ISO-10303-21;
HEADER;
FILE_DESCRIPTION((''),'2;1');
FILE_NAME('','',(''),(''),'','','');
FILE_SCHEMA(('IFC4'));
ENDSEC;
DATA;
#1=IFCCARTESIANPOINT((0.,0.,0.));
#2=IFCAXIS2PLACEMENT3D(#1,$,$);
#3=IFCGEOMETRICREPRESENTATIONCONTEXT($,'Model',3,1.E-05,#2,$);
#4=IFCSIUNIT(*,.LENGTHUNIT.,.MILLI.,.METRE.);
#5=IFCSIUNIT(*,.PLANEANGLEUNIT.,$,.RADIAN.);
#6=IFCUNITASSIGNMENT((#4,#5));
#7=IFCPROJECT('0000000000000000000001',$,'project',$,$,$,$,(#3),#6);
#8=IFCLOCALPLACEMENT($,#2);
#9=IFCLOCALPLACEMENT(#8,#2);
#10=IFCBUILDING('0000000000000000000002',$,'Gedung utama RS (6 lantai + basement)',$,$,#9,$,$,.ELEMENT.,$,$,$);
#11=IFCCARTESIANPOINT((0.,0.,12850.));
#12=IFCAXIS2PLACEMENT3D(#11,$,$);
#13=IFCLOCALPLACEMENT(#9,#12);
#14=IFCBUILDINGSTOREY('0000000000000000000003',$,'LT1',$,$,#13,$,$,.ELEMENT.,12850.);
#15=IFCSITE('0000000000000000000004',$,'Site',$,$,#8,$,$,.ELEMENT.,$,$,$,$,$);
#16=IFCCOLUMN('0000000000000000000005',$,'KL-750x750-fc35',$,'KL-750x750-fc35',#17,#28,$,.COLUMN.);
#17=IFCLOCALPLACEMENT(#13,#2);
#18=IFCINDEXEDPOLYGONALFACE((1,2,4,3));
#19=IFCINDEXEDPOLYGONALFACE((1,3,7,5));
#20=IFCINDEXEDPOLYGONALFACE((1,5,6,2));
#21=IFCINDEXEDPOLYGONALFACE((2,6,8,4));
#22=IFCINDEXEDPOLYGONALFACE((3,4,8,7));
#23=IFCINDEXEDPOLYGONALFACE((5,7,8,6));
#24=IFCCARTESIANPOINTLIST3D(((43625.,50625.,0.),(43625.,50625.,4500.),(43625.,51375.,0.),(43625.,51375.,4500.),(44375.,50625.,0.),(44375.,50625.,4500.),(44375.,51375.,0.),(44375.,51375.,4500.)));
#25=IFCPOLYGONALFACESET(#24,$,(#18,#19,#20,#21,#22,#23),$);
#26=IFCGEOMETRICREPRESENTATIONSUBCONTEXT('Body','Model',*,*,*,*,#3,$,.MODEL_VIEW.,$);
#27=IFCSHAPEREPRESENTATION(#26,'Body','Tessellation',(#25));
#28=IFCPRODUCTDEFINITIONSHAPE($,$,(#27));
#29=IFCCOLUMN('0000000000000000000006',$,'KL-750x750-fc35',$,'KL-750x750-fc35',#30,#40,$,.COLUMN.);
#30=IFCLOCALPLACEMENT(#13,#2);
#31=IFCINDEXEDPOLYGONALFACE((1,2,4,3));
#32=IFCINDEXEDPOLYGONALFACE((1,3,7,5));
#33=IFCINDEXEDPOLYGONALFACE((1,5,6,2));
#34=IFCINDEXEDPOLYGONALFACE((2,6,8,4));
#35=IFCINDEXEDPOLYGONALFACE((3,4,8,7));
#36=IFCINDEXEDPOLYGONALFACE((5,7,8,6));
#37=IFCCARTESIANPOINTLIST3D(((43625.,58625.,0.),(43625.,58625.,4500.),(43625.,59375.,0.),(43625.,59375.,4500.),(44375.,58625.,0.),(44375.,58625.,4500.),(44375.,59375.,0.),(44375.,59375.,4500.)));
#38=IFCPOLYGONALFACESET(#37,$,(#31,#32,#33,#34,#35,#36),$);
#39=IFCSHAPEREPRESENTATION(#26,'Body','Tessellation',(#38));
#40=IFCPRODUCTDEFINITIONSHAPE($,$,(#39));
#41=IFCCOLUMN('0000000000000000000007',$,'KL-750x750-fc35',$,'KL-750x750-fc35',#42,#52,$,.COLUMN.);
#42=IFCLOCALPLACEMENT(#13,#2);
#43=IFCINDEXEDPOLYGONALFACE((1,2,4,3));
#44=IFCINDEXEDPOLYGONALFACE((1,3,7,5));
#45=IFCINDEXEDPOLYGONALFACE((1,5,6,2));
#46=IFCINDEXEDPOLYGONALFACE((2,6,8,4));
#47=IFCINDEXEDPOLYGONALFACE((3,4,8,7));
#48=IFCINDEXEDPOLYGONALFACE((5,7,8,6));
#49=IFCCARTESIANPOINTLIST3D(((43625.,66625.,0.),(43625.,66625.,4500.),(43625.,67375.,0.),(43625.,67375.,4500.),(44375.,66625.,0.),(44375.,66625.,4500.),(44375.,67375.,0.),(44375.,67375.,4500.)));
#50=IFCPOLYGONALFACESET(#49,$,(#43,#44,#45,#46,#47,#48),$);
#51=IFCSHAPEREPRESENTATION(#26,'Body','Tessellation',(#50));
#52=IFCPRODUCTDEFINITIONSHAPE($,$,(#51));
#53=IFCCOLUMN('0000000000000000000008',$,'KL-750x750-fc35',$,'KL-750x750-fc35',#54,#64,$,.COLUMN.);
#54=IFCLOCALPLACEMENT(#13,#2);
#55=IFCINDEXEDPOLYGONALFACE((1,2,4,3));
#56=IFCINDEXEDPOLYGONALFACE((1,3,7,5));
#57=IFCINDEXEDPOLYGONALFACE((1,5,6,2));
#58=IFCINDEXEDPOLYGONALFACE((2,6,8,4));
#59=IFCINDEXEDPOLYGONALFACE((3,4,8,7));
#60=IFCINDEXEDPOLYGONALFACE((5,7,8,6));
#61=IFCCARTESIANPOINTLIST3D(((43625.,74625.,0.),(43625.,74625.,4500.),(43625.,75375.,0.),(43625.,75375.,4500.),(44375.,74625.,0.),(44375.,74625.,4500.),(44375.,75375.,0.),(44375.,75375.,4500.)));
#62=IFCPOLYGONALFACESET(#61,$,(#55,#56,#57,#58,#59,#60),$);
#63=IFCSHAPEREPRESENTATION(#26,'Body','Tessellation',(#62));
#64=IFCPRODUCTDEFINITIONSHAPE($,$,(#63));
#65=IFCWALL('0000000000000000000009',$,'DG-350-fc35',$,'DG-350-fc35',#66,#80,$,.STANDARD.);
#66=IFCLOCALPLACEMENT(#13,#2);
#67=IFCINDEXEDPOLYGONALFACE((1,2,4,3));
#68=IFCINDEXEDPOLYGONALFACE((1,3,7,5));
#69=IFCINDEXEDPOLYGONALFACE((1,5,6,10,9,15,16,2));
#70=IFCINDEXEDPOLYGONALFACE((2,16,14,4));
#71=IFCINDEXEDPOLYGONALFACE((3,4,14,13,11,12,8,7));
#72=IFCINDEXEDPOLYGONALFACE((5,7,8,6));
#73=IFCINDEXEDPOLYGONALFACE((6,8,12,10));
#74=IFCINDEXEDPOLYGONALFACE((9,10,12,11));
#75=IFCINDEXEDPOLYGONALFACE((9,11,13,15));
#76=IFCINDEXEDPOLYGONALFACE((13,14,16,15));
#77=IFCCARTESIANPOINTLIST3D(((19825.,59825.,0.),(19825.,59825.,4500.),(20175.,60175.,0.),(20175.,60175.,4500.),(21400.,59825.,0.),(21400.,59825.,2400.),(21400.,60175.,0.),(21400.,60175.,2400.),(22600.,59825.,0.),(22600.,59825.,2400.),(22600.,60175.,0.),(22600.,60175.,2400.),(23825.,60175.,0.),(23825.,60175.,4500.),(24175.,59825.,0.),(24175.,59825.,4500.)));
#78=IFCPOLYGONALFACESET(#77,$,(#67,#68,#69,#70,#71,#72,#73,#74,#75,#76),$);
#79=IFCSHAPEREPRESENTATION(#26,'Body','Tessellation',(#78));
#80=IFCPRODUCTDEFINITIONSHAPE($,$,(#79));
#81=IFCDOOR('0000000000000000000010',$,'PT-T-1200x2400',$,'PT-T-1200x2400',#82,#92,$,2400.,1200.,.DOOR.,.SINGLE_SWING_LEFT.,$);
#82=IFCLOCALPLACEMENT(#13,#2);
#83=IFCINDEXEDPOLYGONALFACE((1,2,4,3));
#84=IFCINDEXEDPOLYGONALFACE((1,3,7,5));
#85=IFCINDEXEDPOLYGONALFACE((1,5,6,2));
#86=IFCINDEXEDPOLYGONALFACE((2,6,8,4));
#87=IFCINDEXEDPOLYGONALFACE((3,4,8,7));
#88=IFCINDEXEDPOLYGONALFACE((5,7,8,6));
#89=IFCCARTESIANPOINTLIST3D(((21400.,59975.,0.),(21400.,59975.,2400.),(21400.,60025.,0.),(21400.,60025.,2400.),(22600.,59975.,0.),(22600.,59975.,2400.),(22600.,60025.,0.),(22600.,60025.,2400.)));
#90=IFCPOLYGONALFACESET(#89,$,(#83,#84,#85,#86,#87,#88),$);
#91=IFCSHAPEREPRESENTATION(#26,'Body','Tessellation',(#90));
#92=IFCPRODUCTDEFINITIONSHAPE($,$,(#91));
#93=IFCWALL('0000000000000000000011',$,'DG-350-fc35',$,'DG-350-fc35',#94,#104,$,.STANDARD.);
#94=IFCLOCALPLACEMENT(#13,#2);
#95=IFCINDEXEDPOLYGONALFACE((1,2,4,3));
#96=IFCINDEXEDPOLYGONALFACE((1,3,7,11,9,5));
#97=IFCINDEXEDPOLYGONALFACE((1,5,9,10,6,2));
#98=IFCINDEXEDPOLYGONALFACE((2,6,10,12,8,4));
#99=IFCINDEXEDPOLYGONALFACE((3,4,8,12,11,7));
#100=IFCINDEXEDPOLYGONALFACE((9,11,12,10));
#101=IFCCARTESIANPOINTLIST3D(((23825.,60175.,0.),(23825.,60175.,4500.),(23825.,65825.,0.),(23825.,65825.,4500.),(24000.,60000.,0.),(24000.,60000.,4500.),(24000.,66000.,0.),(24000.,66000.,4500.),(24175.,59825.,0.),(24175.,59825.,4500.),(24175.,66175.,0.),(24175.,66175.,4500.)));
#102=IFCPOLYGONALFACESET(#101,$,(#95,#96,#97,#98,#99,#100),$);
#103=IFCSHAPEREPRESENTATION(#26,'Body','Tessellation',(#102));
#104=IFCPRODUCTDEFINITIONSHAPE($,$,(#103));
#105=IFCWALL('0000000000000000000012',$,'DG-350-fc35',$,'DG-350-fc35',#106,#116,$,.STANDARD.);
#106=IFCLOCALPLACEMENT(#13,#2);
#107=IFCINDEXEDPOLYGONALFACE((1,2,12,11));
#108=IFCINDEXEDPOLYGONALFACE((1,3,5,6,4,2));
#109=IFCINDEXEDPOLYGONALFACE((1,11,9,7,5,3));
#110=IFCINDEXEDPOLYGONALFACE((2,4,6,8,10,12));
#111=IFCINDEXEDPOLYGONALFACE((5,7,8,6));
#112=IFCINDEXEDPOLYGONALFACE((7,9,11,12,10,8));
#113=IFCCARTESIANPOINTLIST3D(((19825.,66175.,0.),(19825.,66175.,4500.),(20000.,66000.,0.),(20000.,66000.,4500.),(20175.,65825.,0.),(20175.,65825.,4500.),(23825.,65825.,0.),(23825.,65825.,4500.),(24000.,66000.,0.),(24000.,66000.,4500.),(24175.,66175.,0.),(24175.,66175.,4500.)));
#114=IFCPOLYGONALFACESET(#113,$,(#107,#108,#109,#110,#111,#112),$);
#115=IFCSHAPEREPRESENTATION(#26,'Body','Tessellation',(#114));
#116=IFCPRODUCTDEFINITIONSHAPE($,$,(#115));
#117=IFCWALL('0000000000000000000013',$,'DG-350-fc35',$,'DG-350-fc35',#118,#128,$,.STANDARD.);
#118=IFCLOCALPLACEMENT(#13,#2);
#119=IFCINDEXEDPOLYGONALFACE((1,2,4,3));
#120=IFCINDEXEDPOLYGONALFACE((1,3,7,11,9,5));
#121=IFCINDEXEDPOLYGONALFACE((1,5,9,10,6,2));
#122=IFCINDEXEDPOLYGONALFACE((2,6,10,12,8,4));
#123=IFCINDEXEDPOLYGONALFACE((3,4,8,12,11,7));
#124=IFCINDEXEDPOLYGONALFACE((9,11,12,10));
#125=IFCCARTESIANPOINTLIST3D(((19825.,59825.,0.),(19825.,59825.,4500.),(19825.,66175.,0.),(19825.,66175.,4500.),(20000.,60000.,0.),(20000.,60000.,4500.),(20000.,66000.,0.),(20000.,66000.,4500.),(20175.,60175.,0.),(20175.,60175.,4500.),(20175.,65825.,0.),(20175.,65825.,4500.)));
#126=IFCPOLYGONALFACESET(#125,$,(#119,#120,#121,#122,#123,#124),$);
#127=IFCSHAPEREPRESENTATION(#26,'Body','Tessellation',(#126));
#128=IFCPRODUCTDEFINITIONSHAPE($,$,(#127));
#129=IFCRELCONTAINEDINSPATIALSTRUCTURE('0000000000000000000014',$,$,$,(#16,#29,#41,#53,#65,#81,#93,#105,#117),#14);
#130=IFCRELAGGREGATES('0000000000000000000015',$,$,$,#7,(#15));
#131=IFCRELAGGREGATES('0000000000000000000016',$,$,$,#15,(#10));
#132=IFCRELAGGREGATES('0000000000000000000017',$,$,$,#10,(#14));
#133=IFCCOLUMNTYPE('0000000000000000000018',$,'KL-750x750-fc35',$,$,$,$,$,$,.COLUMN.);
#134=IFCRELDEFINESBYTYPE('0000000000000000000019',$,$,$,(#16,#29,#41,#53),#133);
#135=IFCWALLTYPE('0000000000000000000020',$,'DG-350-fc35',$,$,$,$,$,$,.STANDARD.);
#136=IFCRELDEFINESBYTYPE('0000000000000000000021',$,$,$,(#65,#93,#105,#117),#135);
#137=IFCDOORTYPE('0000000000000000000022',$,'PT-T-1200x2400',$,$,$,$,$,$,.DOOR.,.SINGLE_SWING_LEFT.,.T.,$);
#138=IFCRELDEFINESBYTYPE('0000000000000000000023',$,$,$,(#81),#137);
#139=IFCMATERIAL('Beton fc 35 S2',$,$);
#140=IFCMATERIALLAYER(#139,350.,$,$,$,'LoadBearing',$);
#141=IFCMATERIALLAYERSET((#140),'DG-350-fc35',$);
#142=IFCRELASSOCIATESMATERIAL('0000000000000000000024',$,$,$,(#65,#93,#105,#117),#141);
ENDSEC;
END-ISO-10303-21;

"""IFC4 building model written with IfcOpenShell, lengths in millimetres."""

from ifc_helpers import new_model, si_unit, frame, frame_2d, origin, origin_2d, place, context, subcontext, project, spatial, polyline, rectangle, outline, extrude, material, layer, layer_set, layer_usage, material_profile, profile_set, profile_usage, type_object, element, fill, save


model = new_model("IFC4")

# Units and contexts
model_context = context("Model", 3, precision=1e-05, world=origin())
body_context = subcontext(model_context, "Body", "Model", "MODEL_VIEW")
ifc_project = project(units=[si_unit("LENGTHUNIT", "METRE", prefix="MILLI"), si_unit("PLANEANGLEUNIT", "RADIAN")], contexts=[model_context])

# Site, building, storey
site_placement = place(None, origin())
site = spatial("IfcSite", under=ifc_project, at=site_placement, Name="Site", CompositionType="ELEMENT")
building_placement = place(site_placement, origin())
building = spatial("IfcBuilding", under=site, at=building_placement, Name="Gedung utama RS (6 lantai + basement)", CompositionType="ELEMENT")
storey_placement = place(building_placement, frame((0.0, 0.0, 12850.0)))
storey = spatial("IfcBuildingStorey", under=building, at=storey_placement, Name="LT1", CompositionType="ELEMENT", Elevation=12850.0)

# Columns
ifc_material_profile = material_profile(None, rectangle(XDim=750.0, YDim=750.0, at=origin_2d()), Name="KL-750x750-fc35")
ifc_profile_set = profile_set([ifc_material_profile], Name="KL-750x750-fc35")
ifc_profile_usage = profile_usage(ifc_profile_set, cardinal=5)
column_type = type_object("IfcColumnType", Name="KL-750x750-fc35", PredefinedType="COLUMN", material=ifc_profile_set)
for number, where, z_axis, x_axis, name in (
    (1, (44000.0, 51000.0, 0.0), (0.0, 0.0, 1.0), (1.0, 0.0, 0.0), "KL-750x750-fc35"),
    (2, (44000.0, 59000.0, 0.0), (0.0, 0.0, 1.0), (1.0, 0.0, 0.0), "KL-750x750-fc35"),
    (3, (44000.0, 67000.0, 0.0), (0.0, 0.0, 1.0), (1.0, 0.0, 0.0), "KL-750x750-fc35"),
    (4, (44000.0, 75000.0, 0.0), (0.0, 0.0, 1.0), (1.0, 0.0, 0.0), "KL-750x750-fc35"),
):
    element("IfcColumn", number, at=place(storey_placement, frame(where, z_axis=z_axis, x_axis=x_axis)), inside=storey, type_object=column_type, material=ifc_profile_usage, Name=name, ObjectType="KL-750x750-fc35", PredefinedType="COLUMN", context=body_context, shape_type="SweptSolid", body=[
        extrude(rectangle(XDim=750.0, YDim=750.0, at=origin_2d()), origin(), (0.0, 0.0, 1.0), 4500.0),
    ])

# Wall, opening, door
ifc_material = material(Name="Beton fc 35 S2")
ifc_layer = layer(ifc_material, 350.0, Category="LoadBearing")
ifc_layer_set = layer_set([ifc_layer], Name="DG-350-fc35")
ifc_layer_usage = layer_usage(ifc_layer_set, "AXIS2", "NEGATIVE", 175.0)
wall_type = type_object("IfcWallType", Name="DG-350-fc35", PredefinedType="STANDARD")
wall_1_placement = place(storey_placement, frame((20000.0, 60000.0, 0.0), z_axis=(0.0, 0.0, 1.0), x_axis=(1.0, 0.0, 0.0)))
wall_1 = element("IfcWall", 5, at=wall_1_placement, inside=storey, type_object=wall_type, material=ifc_layer_usage, Name="DG-350-fc35", ObjectType="DG-350-fc35", PredefinedType="STANDARD", context=body_context, shape_type="SweptSolid", body=[
    extrude(outline(polyline([(-175.0, -175.0), (0.0, 0.0), (175.0, 175.0), (3825.0, 175.0), (4000.0, 0.0), (4175.0, -175.0), (-175.0, -175.0)])), origin(), (0.0, 0.0, 1.0), 4500.0),
])
opening_placement = place(wall_1_placement, frame((1400.0, 0.0, 0.0), z_axis=(0.0, 0.0, 1.0), x_axis=(1.0, 0.0, 0.0)))
opening = element("IfcOpeningElement", 6, at=opening_placement, cuts=wall_1, PredefinedType="OPENING", context=body_context, shape_type="SweptSolid", body=[
    extrude(rectangle(XDim=1200.0, YDim=370.0, at=frame_2d((600.0, 0.0))), origin(), (0.0, 0.0, 1.0), 2400.0),
])
door_type = type_object("IfcDoorType", Name="PT-T-1200x2400", OperationType="SINGLE_SWING_LEFT", ParameterTakesPrecedence=True, PredefinedType="DOOR")
door_placement = place(opening_placement, origin())
door = element("IfcDoor", 7, at=door_placement, inside=storey, type_object=door_type, Name="PT-T-1200x2400", ObjectType="PT-T-1200x2400", OperationType="SINGLE_SWING_LEFT", OverallHeight=2400.0, OverallWidth=1200.0, PredefinedType="DOOR", context=body_context, shape_type="SweptSolid", body=[
    extrude(rectangle(XDim=1200.0, YDim=50.0, at=frame_2d((600.0, 0.0))), origin(), (0.0, 0.0, 1.0), 2400.0),
])
fill(opening, door)

# Walls
wall_2_placement = place(storey_placement, frame((24000.0, 60000.0, 0.0), z_axis=(0.0, 0.0, 1.0), x_axis=(0.0, 1.0, 0.0)))
element("IfcWall", 8, at=wall_2_placement, inside=storey, type_object=wall_type, material=ifc_layer_usage, Name="DG-350-fc35", ObjectType="DG-350-fc35", PredefinedType="STANDARD", context=body_context, shape_type="SweptSolid", body=[
    extrude(outline(polyline([(-175.0, -175.0), (0.0, 0.0), (175.0, 175.0), (5825.0, 175.0), (6000.0, 0.0), (6175.0, -175.0), (-175.0, -175.0)])), origin(), (0.0, 0.0, 1.0), 4500.0),
])
wall_3_placement = place(storey_placement, frame((24000.0, 66000.0, 0.0), z_axis=(0.0, 0.0, 1.0), x_axis=(-1.0, 0.0, 0.0)))
element("IfcWall", 9, at=wall_3_placement, inside=storey, type_object=wall_type, material=ifc_layer_usage, Name="DG-350-fc35", ObjectType="DG-350-fc35", PredefinedType="STANDARD", context=body_context, shape_type="SweptSolid", body=[
    extrude(outline(polyline([(-175.0, -175.0), (0.0, 0.0), (175.0, 175.0), (3825.0, 175.0), (4000.0, 0.0), (4175.0, -175.0), (-175.0, -175.0)])), origin(), (0.0, 0.0, 1.0), 4500.0),
])
wall_4_placement = place(storey_placement, frame((20000.0, 66000.0, 0.0), z_axis=(0.0, 0.0, 1.0), x_axis=(0.0, -1.0, 0.0)))
element("IfcWall", 10, at=wall_4_placement, inside=storey, type_object=wall_type, material=ifc_layer_usage, Name="DG-350-fc35", ObjectType="DG-350-fc35", PredefinedType="STANDARD", context=body_context, shape_type="SweptSolid", body=[
    extrude(outline(polyline([(-175.0, -175.0), (0.0, 0.0), (175.0, 175.0), (5825.0, 175.0), (6000.0, 0.0), (6175.0, -175.0), (-175.0, -175.0)])), origin(), (0.0, 0.0, 1.0), 4500.0),
])

save(model, "model.ifc")
